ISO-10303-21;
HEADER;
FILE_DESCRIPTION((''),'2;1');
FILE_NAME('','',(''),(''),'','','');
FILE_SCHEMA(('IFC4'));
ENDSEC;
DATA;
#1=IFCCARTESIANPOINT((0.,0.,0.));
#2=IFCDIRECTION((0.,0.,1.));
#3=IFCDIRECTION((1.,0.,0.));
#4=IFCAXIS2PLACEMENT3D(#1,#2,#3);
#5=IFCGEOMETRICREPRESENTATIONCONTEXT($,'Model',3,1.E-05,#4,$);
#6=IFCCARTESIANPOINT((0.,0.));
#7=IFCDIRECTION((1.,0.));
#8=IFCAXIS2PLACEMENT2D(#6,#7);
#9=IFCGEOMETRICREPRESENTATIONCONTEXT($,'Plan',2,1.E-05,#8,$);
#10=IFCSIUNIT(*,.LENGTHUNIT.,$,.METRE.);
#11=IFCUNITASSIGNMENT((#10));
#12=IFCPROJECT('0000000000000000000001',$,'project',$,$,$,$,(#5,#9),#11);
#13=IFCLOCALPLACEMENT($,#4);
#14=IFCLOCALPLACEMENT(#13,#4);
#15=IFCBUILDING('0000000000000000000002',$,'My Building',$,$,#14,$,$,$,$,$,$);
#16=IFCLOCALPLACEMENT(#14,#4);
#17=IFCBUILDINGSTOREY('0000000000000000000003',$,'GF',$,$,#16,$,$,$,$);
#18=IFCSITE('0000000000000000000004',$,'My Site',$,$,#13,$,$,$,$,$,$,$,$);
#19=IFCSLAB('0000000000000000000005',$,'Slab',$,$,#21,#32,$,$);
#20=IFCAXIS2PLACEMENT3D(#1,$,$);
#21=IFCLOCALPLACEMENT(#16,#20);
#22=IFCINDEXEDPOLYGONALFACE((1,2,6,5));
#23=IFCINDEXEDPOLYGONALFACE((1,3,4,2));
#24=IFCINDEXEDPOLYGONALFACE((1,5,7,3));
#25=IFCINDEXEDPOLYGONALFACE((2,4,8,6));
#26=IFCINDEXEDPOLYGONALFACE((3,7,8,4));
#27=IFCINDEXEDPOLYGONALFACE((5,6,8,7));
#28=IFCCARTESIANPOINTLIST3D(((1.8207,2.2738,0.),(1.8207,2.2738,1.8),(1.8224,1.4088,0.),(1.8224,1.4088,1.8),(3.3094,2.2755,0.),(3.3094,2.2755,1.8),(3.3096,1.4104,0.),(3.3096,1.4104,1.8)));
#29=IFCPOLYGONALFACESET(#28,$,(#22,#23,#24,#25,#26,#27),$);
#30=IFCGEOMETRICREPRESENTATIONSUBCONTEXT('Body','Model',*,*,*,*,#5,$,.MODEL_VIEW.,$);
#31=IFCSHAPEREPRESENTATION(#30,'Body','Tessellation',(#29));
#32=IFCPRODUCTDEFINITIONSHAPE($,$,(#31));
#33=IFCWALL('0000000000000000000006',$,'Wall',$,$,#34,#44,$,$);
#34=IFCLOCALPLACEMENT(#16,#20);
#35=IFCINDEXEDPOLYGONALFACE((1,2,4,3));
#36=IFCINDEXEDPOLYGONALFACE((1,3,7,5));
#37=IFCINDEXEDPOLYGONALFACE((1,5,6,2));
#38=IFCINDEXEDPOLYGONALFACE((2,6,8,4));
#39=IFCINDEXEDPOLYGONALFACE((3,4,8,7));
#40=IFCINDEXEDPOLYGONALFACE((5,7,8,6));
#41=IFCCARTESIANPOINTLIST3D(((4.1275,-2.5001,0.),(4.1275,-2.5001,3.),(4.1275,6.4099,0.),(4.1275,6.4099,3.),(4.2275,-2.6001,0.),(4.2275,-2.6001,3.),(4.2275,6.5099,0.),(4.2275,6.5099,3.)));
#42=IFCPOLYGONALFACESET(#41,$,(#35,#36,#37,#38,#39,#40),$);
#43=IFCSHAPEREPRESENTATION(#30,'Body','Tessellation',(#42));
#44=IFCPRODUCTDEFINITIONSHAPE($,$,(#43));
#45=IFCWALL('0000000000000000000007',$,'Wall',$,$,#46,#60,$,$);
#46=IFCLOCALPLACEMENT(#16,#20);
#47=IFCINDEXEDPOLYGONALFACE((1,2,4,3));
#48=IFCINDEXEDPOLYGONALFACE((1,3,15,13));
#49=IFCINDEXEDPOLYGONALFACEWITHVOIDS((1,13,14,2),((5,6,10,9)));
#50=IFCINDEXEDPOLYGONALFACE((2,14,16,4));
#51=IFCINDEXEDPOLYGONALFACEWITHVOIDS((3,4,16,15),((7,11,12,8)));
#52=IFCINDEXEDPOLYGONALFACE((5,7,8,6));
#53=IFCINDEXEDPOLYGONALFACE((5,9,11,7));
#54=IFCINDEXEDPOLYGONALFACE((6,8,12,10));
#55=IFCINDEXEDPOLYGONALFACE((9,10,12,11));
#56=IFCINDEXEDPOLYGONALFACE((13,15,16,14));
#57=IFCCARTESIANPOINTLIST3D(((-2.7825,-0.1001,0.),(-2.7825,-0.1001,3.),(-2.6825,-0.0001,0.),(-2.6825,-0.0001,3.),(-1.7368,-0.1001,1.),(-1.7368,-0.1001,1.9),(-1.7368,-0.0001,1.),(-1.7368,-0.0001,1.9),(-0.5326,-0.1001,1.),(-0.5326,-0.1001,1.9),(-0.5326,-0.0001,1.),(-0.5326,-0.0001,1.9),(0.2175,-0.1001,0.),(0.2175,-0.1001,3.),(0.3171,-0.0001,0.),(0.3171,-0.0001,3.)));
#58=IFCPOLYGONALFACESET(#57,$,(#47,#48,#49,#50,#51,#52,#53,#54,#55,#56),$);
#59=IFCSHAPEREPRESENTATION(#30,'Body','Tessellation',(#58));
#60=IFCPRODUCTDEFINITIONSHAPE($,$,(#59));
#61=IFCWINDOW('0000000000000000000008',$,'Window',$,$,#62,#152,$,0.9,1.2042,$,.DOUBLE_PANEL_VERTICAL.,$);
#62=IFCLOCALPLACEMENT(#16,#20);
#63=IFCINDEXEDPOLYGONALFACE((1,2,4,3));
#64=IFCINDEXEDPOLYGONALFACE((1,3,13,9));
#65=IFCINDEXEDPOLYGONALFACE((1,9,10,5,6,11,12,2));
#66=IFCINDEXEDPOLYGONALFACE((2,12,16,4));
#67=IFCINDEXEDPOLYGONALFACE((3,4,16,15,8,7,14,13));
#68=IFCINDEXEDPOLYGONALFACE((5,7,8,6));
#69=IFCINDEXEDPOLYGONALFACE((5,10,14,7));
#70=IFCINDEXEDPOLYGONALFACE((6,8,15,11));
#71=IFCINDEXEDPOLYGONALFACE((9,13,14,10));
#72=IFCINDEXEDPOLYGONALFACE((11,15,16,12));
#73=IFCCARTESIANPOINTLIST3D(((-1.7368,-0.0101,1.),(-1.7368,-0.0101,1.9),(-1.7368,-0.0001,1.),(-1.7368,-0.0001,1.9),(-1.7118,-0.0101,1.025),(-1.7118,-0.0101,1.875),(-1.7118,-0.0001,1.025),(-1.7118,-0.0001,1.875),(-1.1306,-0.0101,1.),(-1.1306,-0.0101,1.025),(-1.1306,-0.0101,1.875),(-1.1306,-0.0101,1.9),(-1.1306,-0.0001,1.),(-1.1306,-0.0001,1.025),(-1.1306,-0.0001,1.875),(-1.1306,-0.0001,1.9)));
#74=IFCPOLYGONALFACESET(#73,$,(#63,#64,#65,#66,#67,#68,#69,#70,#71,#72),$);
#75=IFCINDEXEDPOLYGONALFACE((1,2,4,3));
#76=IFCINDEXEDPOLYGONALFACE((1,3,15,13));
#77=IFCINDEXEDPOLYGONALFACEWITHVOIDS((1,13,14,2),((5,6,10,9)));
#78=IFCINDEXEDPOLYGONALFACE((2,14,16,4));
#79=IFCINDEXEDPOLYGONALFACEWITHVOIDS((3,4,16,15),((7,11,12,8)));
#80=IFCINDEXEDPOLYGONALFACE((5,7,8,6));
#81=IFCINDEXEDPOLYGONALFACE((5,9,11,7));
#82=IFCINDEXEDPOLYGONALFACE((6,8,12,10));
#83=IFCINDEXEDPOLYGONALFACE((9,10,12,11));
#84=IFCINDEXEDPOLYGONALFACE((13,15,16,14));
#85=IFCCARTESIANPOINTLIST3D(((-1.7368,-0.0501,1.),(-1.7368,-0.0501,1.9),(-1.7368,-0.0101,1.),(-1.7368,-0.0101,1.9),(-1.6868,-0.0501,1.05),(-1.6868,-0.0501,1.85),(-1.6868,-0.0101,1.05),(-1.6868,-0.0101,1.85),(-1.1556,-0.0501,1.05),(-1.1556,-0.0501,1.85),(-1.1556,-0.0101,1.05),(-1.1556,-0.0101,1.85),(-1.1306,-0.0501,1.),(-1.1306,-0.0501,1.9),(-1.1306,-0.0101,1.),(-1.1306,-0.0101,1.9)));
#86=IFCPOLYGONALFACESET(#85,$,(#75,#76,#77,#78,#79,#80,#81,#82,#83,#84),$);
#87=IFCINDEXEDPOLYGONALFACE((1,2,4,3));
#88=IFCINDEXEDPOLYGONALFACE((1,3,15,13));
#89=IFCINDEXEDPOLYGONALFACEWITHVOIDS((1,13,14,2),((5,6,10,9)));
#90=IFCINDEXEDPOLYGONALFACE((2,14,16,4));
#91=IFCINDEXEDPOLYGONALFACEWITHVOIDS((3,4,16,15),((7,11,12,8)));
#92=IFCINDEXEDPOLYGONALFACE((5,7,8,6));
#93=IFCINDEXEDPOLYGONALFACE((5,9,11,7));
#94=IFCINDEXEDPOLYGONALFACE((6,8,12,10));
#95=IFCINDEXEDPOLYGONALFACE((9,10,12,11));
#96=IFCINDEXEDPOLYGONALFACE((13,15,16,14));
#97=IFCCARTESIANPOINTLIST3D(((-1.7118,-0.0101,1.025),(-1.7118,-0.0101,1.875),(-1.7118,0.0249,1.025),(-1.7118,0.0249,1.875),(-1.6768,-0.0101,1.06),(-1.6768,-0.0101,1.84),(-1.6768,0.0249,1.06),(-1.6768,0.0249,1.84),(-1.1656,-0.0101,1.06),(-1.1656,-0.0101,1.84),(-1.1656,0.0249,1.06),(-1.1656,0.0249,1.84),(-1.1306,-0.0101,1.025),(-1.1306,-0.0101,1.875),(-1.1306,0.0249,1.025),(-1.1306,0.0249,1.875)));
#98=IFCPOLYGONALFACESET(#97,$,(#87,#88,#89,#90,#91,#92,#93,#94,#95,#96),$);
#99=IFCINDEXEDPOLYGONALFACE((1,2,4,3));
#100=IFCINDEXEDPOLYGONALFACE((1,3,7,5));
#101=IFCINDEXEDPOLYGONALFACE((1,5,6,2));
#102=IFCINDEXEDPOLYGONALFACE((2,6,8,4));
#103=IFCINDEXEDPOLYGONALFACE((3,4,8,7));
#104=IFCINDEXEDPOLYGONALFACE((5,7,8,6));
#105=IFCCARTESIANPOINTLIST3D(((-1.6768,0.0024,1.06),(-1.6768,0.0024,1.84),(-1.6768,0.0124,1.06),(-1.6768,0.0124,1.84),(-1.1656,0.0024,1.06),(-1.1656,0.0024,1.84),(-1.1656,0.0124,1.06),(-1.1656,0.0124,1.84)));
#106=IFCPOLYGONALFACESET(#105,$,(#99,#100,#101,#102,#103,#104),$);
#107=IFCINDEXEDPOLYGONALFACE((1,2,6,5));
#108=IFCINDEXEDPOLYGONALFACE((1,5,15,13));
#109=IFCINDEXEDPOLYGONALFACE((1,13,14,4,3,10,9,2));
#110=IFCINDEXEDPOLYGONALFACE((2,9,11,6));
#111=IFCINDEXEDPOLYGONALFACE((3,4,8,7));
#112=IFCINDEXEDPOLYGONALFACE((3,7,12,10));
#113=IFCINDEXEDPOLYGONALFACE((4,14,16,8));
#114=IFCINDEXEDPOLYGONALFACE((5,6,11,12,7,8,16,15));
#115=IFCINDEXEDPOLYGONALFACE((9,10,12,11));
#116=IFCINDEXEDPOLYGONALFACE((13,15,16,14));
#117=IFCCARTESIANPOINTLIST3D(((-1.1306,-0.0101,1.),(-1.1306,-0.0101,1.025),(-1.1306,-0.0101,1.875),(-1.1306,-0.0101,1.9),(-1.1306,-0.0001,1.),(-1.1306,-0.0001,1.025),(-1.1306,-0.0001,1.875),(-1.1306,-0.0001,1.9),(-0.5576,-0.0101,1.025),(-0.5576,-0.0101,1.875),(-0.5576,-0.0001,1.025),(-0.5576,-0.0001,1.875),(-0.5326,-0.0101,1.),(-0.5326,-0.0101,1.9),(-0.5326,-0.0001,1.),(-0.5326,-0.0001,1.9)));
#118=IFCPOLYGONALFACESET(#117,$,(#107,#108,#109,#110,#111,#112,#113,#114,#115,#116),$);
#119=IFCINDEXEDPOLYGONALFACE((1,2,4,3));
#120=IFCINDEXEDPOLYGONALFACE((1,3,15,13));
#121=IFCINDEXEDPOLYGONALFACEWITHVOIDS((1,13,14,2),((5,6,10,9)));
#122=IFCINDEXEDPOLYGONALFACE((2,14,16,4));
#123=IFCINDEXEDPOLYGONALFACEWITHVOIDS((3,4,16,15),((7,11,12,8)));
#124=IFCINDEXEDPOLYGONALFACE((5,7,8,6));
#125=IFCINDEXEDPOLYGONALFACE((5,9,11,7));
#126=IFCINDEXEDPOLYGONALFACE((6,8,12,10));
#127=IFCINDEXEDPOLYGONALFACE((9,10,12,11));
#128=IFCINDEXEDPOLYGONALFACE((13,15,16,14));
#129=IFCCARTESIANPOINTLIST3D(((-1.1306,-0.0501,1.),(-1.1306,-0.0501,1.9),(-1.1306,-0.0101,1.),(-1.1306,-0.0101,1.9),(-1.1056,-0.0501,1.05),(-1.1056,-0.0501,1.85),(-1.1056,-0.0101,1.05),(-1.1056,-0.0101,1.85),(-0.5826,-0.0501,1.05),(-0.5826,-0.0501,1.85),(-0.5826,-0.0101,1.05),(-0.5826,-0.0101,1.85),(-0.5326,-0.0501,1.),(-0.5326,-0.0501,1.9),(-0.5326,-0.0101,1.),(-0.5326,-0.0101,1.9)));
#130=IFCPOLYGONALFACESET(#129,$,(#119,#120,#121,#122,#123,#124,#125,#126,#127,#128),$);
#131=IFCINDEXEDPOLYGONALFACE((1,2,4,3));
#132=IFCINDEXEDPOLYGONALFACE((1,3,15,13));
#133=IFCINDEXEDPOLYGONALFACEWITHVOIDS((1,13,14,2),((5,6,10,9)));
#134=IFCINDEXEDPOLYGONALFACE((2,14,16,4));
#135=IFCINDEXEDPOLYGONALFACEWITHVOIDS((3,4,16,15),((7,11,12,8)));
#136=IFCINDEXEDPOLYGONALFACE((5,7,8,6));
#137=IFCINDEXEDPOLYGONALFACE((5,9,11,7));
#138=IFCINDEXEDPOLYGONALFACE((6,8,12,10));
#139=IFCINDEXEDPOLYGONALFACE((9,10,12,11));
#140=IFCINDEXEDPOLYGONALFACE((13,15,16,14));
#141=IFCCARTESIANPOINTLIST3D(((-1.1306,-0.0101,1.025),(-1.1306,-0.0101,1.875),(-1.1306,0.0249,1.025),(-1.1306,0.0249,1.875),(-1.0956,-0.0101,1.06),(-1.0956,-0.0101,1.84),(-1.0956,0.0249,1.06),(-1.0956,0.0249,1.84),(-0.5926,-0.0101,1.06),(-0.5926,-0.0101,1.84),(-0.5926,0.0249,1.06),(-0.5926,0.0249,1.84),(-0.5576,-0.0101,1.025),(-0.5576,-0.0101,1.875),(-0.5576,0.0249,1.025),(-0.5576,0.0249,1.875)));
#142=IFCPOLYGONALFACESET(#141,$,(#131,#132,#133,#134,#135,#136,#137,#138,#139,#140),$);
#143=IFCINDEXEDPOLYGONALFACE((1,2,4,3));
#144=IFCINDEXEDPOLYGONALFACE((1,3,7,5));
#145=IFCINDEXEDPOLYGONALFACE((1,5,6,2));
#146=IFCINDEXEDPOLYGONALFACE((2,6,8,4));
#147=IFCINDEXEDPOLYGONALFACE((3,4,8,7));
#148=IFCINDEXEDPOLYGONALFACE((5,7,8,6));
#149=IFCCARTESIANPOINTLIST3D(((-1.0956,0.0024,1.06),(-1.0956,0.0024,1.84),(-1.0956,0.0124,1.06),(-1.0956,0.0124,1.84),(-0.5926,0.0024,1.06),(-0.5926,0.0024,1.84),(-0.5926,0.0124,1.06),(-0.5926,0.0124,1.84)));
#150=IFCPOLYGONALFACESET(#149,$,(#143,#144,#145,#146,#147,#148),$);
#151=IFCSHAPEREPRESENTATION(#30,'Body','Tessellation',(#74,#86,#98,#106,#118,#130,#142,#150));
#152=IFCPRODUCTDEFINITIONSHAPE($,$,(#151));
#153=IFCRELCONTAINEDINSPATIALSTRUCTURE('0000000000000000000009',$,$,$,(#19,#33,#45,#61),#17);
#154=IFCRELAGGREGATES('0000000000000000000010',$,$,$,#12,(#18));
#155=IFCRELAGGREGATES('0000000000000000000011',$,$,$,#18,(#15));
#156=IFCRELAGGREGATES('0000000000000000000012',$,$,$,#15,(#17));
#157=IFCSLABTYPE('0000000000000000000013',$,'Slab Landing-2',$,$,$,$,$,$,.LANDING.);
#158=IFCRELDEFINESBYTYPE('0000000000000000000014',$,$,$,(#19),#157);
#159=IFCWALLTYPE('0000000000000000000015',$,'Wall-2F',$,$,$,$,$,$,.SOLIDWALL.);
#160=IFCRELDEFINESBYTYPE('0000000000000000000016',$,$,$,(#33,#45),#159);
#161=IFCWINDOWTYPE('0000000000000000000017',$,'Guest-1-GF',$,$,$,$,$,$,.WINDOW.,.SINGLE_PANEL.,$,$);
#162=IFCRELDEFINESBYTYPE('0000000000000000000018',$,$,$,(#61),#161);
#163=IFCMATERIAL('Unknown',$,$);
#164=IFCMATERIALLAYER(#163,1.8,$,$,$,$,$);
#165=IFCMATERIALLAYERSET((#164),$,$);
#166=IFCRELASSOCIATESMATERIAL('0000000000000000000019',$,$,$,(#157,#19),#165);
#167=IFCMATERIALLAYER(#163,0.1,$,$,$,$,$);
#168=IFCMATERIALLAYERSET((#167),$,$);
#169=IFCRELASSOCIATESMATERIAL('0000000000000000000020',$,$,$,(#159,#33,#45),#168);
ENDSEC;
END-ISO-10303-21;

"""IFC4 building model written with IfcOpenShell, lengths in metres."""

from ifc_helpers import new_model, entity, si_unit, frame, origin_with_axes, origin_2d_with_axis, place, context, subcontext, project, spatial, line, indexed_curve, outline, extrude, shape, source, transform, mapped, material, layer, layer_set, layer_usage, type_object, type_shapes, element, fill, save


model = new_model("IFC4")

# Units and contexts
model_context = context("Model", 3, precision=1e-05, world=origin_with_axes())
plan_context = context("Plan", 2, precision=1e-05, world=origin_2d_with_axis())
body_context_1 = subcontext(model_context, "Body", "Model", "MODEL_VIEW")
body_context_2 = subcontext(plan_context, "Body", "Plan", "PLAN_VIEW")
ifc_project = project(units=[si_unit("LENGTHUNIT", "METRE")], contexts=[model_context, plan_context])

# Site, building, storey
site_placement = place(None, origin_with_axes())
site = spatial("IfcSite", under=ifc_project, at=site_placement, Name="My Site")
building_placement = place(site_placement, origin_with_axes())
building = spatial("IfcBuilding", under=site, at=building_placement, Name="My Building")
storey_placement = place(building_placement, origin_with_axes())
storey = spatial("IfcBuildingStorey", under=building, at=storey_placement, Name="GF")

# Shared definitions
ifc_material = material(Name="Unknown")

# Slab
ifc_layer_1 = layer(ifc_material, 1.8)
ifc_layer_set_1 = layer_set([ifc_layer_1])
ifc_layer_usage_1 = layer_usage(ifc_layer_set_1, "AXIS3", "POSITIVE", -1.8)
slab_type_1 = type_object("IfcSlabType", Name="Slab Landing-2", PredefinedType="LANDING", material=ifc_layer_set_1)
slab_1_placement = place(storey_placement, frame((3.3094, 2.2755, 1.8), z_axis=(0.0, 0.0, 1.0), x_axis=(1.0, 0.0, 0.0)))
element("IfcSlab", 1, at=slab_1_placement, inside=storey, type_object=slab_type_1, material=ifc_layer_usage_1, Name="Slab", context=body_context_1, shape_type="SweptSolid", body=[
    extrude(outline(indexed_curve([(0.0, 0.0), (0.0002, -0.8651), (-1.487, -0.8667), (-1.4887, -0.0017), (0.0, 0.0)])), frame((0.0, 0.0, -1.8), z_axis=(0.0, 0.0, 1.0), x_axis=(1.0, 0.0, 0.0)), (0.0, 0.0, 1.0), 1.8),
])

# Shared definitions
ifc_layer_2 = layer(ifc_material, 0.1)
ifc_layer_set_2 = layer_set([ifc_layer_2])
wall_type = type_object("IfcWallType", Name="Wall-2F", PredefinedType="SOLIDWALL", material=ifc_layer_set_2)

# Wall
ifc_layer_usage_2 = layer_usage(ifc_layer_set_2, "AXIS2", "POSITIVE", 0.0)
wall_1_placement = place(storey_placement, frame((4.2275, -2.6001, 0.0), z_axis=(0.0, 0.0, 1.0), x_axis=(0.0, 1.0, 0.0)))
element("IfcWall", 2, at=wall_1_placement, inside=storey, type_object=wall_type, material=ifc_layer_usage_2, Name="Wall", context=body_context_1, shape_type="SweptSolid", body=[
    extrude(outline(indexed_curve([(0.0, 0.0), (0.1, 0.1), (9.01, 0.1), (9.11, 0.0)], segments=[line(1, 2, 3, 4, 1)])), origin_with_axes(), (0.0, 0.0, 1.0), 3.0),
])

# Wall, opening, window
ifc_layer_usage_3 = layer_usage(ifc_layer_set_2, "AXIS2", "POSITIVE", 0.0)
wall_2_placement = place(storey_placement, frame((-2.7825, -0.1001, 0.0), z_axis=(0.0, 0.0, 1.0), x_axis=(1.0, 0.0, 0.0)))
wall_2 = element("IfcWall", 3, at=wall_2_placement, inside=storey, type_object=wall_type, material=ifc_layer_usage_3, Name="Wall", context=body_context_1, shape_type="SweptSolid", body=[
    extrude(outline(indexed_curve([(0.0, 0.0), (0.1, 0.1), (3.0996, 0.1), (3.0, 0.0)], segments=[line(1, 2, 3, 4, 1)])), origin_with_axes(), (0.0, 0.0, 1.0), 3.0),
])
shared_shape_1 = source(origin_with_axes(), body_context_1, "Body", "SweptSolid", [
    extrude(outline(indexed_curve([(0.0, 0.0), (1.2042, 0.0), (1.2042, 0.9), (0.0, 0.9)], segments=[line(1, 2, 3, 4, 1)])), frame((0.0, -0.6, 0.0), z_axis=(0.0, -1.0, 0.0), x_axis=(1.0, 0.0, 0.0)), (0.0, 0.0, -1.0), 1.2),
])
opening_1_placement = place(wall_2_placement, frame((1.0457, 0.0, 1.0), z_axis=(0.0, 0.0, 1.0), x_axis=(1.0, 0.0, 0.0)))
opening_1 = element("IfcOpeningElement", 4, at=opening_1_placement, cuts=wall_2, PredefinedType="OPENING", context=body_context_1, shape_type="MappedRepresentation", body=[
    mapped(shared_shape_1, transform((0.0, 0.0, 0.0), x_axis=(1.0, 0.0, 0.0), y_axis=(0.0, 1.0, 0.0), z_axis=(0.0, 0.0, 1.0), scale=1.0)),
])
window_type_1 = type_object("IfcWindowType", Name="Guest-1-GF", PartitioningType="SINGLE_PANEL", PredefinedType="WINDOW")
shared_shape_2 = source(origin_with_axes(), body_context_1, "Body", "SweptSolid", [
    extrude(outline(indexed_curve([(0.6062, 0.0), (0.0, 0.0), (0.0, 0.9), (0.6062, 0.9), (0.6062, 0.875), (0.025, 0.875), (0.025, 0.025), (0.6062, 0.025)], segments=[line(1, 2, 3, 4, 5, 6, 7, 8, 1)])), frame((0.0, 0.09, 0.0), z_axis=(0.0, -1.0, 0.0), x_axis=(1.0, 0.0, 0.0)), (0.0, 0.0, -1.0), 0.01),
    extrude(outline(indexed_curve([(0.0, 0.0), (0.6062, 0.0), (0.6062, 0.9), (0.0, 0.9)], segments=[line(1, 2, 3, 4, 1)]), holes=[indexed_curve([(0.05, 0.05), (0.5812, 0.05), (0.5812, 0.85), (0.05, 0.85)], segments=[line(1, 2, 3, 4, 1)])]), frame((0.0, 0.05, 0.0), z_axis=(0.0, -1.0, 0.0), x_axis=(1.0, 0.0, 0.0)), (0.0, 0.0, -1.0), 0.04),
    extrude(outline(indexed_curve([(0.0, 0.0), (0.5812, 0.0), (0.5812, 0.85), (0.0, 0.85)], segments=[line(1, 2, 3, 4, 1)]), holes=[indexed_curve([(0.035, 0.035), (0.5462, 0.035), (0.5462, 0.815), (0.035, 0.815)], segments=[line(1, 2, 3, 4, 1)])]), frame((0.025, 0.09, 0.025), z_axis=(0.0, -1.0, 0.0), x_axis=(1.0, 0.0, 0.0)), (0.0, 0.0, -1.0), 0.035),
    extrude(outline(indexed_curve([(0.035, 0.035), (0.5462, 0.035), (0.5462, 0.815), (0.035, 0.815)], segments=[line(1, 2, 3, 4, 1)])), frame((0.025, 0.1025, 0.025), z_axis=(0.0, -1.0, 0.0), x_axis=(1.0, 0.0, 0.0)), (0.0, 0.0, -1.0), 0.01),
    extrude(outline(indexed_curve([(0.0, 0.9), (0.598, 0.9), (0.598, 0.0), (0.0, 0.0), (0.0, 0.025), (0.573, 0.025), (0.573, 0.875), (0.0, 0.875)], segments=[line(1, 2, 3, 4, 5, 6, 7, 8, 1)])), frame((0.6062, 0.09, 0.0), z_axis=(0.0, -1.0, 0.0), x_axis=(1.0, 0.0, 0.0)), (0.0, 0.0, -1.0), 0.01),
    extrude(outline(indexed_curve([(0.0, 0.0), (0.598, 0.0), (0.598, 0.9), (0.0, 0.9)], segments=[line(1, 2, 3, 4, 1)]), holes=[indexed_curve([(0.025, 0.05), (0.548, 0.05), (0.548, 0.85), (0.025, 0.85)], segments=[line(1, 2, 3, 4, 1)])]), frame((0.6062, 0.05, 0.0), z_axis=(0.0, -1.0, 0.0), x_axis=(1.0, 0.0, 0.0)), (0.0, 0.0, -1.0), 0.04),
    extrude(outline(indexed_curve([(0.0, 0.0), (0.573, 0.0), (0.573, 0.85), (0.0, 0.85)], segments=[line(1, 2, 3, 4, 1)]), holes=[indexed_curve([(0.035, 0.035), (0.538, 0.035), (0.538, 0.815), (0.035, 0.815)], segments=[line(1, 2, 3, 4, 1)])]), frame((0.6062, 0.09, 0.025), z_axis=(0.0, -1.0, 0.0), x_axis=(1.0, 0.0, 0.0)), (0.0, 0.0, -1.0), 0.035),
    extrude(outline(indexed_curve([(0.035, 0.035), (0.538, 0.035), (0.538, 0.815), (0.035, 0.815)], segments=[line(1, 2, 3, 4, 1)])), frame((0.6062, 0.1025, 0.025), z_axis=(0.0, -1.0, 0.0), x_axis=(1.0, 0.0, 0.0)), (0.0, 0.0, -1.0), 0.01),
])
shared_shape_3 = source(origin_with_axes(), body_context_2, "Body", "Curve2D", [
    entity("IfcIndexedPolyCurve", entity("IfcCartesianPointList2D", [[0.05, 0.05], [0.5812, 0.05]])),
    entity("IfcIndexedPolyCurve", entity("IfcCartesianPointList2D", [[0.0, 0.1], [0.025, 0.1], [0.025, 0.09], [0.05, 0.09], [0.05, 0.05], [0.0, 0.05]]), [entity("IfcLineIndex", [1, 2, 3, 4, 5, 6, 1])]),
    entity("IfcIndexedPolyCurve", entity("IfcCartesianPointList2D", [[0.6062, 0.1], [0.6062, 0.1], [0.6062, 0.09], [0.5812, 0.09], [0.5812, 0.05], [0.6062, 0.05]])),
    entity("IfcIndexedPolyCurve", entity("IfcCartesianPointList2D", [[0.025, 0.09], [0.06, 0.09], [0.06, 0.125], [0.025, 0.125]]), [entity("IfcLineIndex", [1, 2, 3, 4, 1])]),
    entity("IfcIndexedPolyCurve", entity("IfcCartesianPointList2D", [[0.6062, 0.09], [0.5712, 0.09], [0.5712, 0.125], [0.6062, 0.125]]), [entity("IfcLineIndex", [1, 2, 3, 4, 1])]),
    entity("IfcIndexedPolyCurve", entity("IfcCartesianPointList2D", [[0.06, 0.09], [0.5712, 0.09]])),
    entity("IfcIndexedPolyCurve", entity("IfcCartesianPointList2D", [[0.06, 0.125], [0.5712, 0.125]])),
    entity("IfcIndexedPolyCurve", entity("IfcCartesianPointList2D", [[0.06, 0.1075], [0.5712, 0.1075]])),
    entity("IfcIndexedPolyCurve", entity("IfcCartesianPointList2D", [[0.6312, 0.05], [1.1542, 0.05]])),
    entity("IfcIndexedPolyCurve", entity("IfcCartesianPointList2D", [[0.6062, 0.1], [0.6062, 0.1], [0.6062, 0.09], [0.6312, 0.09], [0.6312, 0.05], [0.6062, 0.05]])),
    entity("IfcIndexedPolyCurve", entity("IfcCartesianPointList2D", [[1.2042, 0.1], [1.1792, 0.1], [1.1792, 0.09], [1.1542, 0.09], [1.1542, 0.05], [1.2042, 0.05]]), [entity("IfcLineIndex", [1, 2, 3, 4, 5, 6, 1])]),
    entity("IfcIndexedPolyCurve", entity("IfcCartesianPointList2D", [[0.6062, 0.09], [0.6412, 0.09], [0.6412, 0.125], [0.6062, 0.125]]), [entity("IfcLineIndex", [1, 2, 3, 4, 1])]),
    entity("IfcIndexedPolyCurve", entity("IfcCartesianPointList2D", [[1.1792, 0.09], [1.1442, 0.09], [1.1442, 0.125], [1.1792, 0.125]]), [entity("IfcLineIndex", [1, 2, 3, 4, 1])]),
    entity("IfcIndexedPolyCurve", entity("IfcCartesianPointList2D", [[0.6412, 0.09], [1.1442, 0.09]])),
    entity("IfcIndexedPolyCurve", entity("IfcCartesianPointList2D", [[0.6412, 0.125], [1.1442, 0.125]])),
    entity("IfcIndexedPolyCurve", entity("IfcCartesianPointList2D", [[0.6412, 0.1075], [1.1442, 0.1075]])),
])
type_shapes(window_type_1, [shared_shape_2, shared_shape_3])
window_1_placement = place(opening_1_placement, frame((0.0, 0.0, 0.0), z_axis=(0.0, 0.0, 1.0), x_axis=(1.0, 0.0, 0.0)))
window_1 = element("IfcWindow", 5, at=window_1_placement, inside=storey, type_object=window_type_1, Name="Window", OverallHeight=0.9, OverallWidth=1.2042, PartitioningType="DOUBLE_PANEL_VERTICAL", shapes=[
    shape(body_context_1, "Body", "MappedRepresentation", [mapped(shared_shape_2, transform((0.0, 0.0, 0.0), x_axis=(1.0, 0.0, 0.0), y_axis=(0.0, 1.0, 0.0), z_axis=(0.0, 0.0, 1.0), scale=1.0))]),
    shape(body_context_2, "Body", "MappedRepresentation", [mapped(shared_shape_3, transform((0.0, 0.0, 0.0), x_axis=(1.0, 0.0, 0.0), y_axis=(0.0, 1.0, 0.0), z_axis=(0.0, 0.0, 1.0), scale=1.0))]),
])
fill(opening_1, window_1)

save(model, "model.ifc")
